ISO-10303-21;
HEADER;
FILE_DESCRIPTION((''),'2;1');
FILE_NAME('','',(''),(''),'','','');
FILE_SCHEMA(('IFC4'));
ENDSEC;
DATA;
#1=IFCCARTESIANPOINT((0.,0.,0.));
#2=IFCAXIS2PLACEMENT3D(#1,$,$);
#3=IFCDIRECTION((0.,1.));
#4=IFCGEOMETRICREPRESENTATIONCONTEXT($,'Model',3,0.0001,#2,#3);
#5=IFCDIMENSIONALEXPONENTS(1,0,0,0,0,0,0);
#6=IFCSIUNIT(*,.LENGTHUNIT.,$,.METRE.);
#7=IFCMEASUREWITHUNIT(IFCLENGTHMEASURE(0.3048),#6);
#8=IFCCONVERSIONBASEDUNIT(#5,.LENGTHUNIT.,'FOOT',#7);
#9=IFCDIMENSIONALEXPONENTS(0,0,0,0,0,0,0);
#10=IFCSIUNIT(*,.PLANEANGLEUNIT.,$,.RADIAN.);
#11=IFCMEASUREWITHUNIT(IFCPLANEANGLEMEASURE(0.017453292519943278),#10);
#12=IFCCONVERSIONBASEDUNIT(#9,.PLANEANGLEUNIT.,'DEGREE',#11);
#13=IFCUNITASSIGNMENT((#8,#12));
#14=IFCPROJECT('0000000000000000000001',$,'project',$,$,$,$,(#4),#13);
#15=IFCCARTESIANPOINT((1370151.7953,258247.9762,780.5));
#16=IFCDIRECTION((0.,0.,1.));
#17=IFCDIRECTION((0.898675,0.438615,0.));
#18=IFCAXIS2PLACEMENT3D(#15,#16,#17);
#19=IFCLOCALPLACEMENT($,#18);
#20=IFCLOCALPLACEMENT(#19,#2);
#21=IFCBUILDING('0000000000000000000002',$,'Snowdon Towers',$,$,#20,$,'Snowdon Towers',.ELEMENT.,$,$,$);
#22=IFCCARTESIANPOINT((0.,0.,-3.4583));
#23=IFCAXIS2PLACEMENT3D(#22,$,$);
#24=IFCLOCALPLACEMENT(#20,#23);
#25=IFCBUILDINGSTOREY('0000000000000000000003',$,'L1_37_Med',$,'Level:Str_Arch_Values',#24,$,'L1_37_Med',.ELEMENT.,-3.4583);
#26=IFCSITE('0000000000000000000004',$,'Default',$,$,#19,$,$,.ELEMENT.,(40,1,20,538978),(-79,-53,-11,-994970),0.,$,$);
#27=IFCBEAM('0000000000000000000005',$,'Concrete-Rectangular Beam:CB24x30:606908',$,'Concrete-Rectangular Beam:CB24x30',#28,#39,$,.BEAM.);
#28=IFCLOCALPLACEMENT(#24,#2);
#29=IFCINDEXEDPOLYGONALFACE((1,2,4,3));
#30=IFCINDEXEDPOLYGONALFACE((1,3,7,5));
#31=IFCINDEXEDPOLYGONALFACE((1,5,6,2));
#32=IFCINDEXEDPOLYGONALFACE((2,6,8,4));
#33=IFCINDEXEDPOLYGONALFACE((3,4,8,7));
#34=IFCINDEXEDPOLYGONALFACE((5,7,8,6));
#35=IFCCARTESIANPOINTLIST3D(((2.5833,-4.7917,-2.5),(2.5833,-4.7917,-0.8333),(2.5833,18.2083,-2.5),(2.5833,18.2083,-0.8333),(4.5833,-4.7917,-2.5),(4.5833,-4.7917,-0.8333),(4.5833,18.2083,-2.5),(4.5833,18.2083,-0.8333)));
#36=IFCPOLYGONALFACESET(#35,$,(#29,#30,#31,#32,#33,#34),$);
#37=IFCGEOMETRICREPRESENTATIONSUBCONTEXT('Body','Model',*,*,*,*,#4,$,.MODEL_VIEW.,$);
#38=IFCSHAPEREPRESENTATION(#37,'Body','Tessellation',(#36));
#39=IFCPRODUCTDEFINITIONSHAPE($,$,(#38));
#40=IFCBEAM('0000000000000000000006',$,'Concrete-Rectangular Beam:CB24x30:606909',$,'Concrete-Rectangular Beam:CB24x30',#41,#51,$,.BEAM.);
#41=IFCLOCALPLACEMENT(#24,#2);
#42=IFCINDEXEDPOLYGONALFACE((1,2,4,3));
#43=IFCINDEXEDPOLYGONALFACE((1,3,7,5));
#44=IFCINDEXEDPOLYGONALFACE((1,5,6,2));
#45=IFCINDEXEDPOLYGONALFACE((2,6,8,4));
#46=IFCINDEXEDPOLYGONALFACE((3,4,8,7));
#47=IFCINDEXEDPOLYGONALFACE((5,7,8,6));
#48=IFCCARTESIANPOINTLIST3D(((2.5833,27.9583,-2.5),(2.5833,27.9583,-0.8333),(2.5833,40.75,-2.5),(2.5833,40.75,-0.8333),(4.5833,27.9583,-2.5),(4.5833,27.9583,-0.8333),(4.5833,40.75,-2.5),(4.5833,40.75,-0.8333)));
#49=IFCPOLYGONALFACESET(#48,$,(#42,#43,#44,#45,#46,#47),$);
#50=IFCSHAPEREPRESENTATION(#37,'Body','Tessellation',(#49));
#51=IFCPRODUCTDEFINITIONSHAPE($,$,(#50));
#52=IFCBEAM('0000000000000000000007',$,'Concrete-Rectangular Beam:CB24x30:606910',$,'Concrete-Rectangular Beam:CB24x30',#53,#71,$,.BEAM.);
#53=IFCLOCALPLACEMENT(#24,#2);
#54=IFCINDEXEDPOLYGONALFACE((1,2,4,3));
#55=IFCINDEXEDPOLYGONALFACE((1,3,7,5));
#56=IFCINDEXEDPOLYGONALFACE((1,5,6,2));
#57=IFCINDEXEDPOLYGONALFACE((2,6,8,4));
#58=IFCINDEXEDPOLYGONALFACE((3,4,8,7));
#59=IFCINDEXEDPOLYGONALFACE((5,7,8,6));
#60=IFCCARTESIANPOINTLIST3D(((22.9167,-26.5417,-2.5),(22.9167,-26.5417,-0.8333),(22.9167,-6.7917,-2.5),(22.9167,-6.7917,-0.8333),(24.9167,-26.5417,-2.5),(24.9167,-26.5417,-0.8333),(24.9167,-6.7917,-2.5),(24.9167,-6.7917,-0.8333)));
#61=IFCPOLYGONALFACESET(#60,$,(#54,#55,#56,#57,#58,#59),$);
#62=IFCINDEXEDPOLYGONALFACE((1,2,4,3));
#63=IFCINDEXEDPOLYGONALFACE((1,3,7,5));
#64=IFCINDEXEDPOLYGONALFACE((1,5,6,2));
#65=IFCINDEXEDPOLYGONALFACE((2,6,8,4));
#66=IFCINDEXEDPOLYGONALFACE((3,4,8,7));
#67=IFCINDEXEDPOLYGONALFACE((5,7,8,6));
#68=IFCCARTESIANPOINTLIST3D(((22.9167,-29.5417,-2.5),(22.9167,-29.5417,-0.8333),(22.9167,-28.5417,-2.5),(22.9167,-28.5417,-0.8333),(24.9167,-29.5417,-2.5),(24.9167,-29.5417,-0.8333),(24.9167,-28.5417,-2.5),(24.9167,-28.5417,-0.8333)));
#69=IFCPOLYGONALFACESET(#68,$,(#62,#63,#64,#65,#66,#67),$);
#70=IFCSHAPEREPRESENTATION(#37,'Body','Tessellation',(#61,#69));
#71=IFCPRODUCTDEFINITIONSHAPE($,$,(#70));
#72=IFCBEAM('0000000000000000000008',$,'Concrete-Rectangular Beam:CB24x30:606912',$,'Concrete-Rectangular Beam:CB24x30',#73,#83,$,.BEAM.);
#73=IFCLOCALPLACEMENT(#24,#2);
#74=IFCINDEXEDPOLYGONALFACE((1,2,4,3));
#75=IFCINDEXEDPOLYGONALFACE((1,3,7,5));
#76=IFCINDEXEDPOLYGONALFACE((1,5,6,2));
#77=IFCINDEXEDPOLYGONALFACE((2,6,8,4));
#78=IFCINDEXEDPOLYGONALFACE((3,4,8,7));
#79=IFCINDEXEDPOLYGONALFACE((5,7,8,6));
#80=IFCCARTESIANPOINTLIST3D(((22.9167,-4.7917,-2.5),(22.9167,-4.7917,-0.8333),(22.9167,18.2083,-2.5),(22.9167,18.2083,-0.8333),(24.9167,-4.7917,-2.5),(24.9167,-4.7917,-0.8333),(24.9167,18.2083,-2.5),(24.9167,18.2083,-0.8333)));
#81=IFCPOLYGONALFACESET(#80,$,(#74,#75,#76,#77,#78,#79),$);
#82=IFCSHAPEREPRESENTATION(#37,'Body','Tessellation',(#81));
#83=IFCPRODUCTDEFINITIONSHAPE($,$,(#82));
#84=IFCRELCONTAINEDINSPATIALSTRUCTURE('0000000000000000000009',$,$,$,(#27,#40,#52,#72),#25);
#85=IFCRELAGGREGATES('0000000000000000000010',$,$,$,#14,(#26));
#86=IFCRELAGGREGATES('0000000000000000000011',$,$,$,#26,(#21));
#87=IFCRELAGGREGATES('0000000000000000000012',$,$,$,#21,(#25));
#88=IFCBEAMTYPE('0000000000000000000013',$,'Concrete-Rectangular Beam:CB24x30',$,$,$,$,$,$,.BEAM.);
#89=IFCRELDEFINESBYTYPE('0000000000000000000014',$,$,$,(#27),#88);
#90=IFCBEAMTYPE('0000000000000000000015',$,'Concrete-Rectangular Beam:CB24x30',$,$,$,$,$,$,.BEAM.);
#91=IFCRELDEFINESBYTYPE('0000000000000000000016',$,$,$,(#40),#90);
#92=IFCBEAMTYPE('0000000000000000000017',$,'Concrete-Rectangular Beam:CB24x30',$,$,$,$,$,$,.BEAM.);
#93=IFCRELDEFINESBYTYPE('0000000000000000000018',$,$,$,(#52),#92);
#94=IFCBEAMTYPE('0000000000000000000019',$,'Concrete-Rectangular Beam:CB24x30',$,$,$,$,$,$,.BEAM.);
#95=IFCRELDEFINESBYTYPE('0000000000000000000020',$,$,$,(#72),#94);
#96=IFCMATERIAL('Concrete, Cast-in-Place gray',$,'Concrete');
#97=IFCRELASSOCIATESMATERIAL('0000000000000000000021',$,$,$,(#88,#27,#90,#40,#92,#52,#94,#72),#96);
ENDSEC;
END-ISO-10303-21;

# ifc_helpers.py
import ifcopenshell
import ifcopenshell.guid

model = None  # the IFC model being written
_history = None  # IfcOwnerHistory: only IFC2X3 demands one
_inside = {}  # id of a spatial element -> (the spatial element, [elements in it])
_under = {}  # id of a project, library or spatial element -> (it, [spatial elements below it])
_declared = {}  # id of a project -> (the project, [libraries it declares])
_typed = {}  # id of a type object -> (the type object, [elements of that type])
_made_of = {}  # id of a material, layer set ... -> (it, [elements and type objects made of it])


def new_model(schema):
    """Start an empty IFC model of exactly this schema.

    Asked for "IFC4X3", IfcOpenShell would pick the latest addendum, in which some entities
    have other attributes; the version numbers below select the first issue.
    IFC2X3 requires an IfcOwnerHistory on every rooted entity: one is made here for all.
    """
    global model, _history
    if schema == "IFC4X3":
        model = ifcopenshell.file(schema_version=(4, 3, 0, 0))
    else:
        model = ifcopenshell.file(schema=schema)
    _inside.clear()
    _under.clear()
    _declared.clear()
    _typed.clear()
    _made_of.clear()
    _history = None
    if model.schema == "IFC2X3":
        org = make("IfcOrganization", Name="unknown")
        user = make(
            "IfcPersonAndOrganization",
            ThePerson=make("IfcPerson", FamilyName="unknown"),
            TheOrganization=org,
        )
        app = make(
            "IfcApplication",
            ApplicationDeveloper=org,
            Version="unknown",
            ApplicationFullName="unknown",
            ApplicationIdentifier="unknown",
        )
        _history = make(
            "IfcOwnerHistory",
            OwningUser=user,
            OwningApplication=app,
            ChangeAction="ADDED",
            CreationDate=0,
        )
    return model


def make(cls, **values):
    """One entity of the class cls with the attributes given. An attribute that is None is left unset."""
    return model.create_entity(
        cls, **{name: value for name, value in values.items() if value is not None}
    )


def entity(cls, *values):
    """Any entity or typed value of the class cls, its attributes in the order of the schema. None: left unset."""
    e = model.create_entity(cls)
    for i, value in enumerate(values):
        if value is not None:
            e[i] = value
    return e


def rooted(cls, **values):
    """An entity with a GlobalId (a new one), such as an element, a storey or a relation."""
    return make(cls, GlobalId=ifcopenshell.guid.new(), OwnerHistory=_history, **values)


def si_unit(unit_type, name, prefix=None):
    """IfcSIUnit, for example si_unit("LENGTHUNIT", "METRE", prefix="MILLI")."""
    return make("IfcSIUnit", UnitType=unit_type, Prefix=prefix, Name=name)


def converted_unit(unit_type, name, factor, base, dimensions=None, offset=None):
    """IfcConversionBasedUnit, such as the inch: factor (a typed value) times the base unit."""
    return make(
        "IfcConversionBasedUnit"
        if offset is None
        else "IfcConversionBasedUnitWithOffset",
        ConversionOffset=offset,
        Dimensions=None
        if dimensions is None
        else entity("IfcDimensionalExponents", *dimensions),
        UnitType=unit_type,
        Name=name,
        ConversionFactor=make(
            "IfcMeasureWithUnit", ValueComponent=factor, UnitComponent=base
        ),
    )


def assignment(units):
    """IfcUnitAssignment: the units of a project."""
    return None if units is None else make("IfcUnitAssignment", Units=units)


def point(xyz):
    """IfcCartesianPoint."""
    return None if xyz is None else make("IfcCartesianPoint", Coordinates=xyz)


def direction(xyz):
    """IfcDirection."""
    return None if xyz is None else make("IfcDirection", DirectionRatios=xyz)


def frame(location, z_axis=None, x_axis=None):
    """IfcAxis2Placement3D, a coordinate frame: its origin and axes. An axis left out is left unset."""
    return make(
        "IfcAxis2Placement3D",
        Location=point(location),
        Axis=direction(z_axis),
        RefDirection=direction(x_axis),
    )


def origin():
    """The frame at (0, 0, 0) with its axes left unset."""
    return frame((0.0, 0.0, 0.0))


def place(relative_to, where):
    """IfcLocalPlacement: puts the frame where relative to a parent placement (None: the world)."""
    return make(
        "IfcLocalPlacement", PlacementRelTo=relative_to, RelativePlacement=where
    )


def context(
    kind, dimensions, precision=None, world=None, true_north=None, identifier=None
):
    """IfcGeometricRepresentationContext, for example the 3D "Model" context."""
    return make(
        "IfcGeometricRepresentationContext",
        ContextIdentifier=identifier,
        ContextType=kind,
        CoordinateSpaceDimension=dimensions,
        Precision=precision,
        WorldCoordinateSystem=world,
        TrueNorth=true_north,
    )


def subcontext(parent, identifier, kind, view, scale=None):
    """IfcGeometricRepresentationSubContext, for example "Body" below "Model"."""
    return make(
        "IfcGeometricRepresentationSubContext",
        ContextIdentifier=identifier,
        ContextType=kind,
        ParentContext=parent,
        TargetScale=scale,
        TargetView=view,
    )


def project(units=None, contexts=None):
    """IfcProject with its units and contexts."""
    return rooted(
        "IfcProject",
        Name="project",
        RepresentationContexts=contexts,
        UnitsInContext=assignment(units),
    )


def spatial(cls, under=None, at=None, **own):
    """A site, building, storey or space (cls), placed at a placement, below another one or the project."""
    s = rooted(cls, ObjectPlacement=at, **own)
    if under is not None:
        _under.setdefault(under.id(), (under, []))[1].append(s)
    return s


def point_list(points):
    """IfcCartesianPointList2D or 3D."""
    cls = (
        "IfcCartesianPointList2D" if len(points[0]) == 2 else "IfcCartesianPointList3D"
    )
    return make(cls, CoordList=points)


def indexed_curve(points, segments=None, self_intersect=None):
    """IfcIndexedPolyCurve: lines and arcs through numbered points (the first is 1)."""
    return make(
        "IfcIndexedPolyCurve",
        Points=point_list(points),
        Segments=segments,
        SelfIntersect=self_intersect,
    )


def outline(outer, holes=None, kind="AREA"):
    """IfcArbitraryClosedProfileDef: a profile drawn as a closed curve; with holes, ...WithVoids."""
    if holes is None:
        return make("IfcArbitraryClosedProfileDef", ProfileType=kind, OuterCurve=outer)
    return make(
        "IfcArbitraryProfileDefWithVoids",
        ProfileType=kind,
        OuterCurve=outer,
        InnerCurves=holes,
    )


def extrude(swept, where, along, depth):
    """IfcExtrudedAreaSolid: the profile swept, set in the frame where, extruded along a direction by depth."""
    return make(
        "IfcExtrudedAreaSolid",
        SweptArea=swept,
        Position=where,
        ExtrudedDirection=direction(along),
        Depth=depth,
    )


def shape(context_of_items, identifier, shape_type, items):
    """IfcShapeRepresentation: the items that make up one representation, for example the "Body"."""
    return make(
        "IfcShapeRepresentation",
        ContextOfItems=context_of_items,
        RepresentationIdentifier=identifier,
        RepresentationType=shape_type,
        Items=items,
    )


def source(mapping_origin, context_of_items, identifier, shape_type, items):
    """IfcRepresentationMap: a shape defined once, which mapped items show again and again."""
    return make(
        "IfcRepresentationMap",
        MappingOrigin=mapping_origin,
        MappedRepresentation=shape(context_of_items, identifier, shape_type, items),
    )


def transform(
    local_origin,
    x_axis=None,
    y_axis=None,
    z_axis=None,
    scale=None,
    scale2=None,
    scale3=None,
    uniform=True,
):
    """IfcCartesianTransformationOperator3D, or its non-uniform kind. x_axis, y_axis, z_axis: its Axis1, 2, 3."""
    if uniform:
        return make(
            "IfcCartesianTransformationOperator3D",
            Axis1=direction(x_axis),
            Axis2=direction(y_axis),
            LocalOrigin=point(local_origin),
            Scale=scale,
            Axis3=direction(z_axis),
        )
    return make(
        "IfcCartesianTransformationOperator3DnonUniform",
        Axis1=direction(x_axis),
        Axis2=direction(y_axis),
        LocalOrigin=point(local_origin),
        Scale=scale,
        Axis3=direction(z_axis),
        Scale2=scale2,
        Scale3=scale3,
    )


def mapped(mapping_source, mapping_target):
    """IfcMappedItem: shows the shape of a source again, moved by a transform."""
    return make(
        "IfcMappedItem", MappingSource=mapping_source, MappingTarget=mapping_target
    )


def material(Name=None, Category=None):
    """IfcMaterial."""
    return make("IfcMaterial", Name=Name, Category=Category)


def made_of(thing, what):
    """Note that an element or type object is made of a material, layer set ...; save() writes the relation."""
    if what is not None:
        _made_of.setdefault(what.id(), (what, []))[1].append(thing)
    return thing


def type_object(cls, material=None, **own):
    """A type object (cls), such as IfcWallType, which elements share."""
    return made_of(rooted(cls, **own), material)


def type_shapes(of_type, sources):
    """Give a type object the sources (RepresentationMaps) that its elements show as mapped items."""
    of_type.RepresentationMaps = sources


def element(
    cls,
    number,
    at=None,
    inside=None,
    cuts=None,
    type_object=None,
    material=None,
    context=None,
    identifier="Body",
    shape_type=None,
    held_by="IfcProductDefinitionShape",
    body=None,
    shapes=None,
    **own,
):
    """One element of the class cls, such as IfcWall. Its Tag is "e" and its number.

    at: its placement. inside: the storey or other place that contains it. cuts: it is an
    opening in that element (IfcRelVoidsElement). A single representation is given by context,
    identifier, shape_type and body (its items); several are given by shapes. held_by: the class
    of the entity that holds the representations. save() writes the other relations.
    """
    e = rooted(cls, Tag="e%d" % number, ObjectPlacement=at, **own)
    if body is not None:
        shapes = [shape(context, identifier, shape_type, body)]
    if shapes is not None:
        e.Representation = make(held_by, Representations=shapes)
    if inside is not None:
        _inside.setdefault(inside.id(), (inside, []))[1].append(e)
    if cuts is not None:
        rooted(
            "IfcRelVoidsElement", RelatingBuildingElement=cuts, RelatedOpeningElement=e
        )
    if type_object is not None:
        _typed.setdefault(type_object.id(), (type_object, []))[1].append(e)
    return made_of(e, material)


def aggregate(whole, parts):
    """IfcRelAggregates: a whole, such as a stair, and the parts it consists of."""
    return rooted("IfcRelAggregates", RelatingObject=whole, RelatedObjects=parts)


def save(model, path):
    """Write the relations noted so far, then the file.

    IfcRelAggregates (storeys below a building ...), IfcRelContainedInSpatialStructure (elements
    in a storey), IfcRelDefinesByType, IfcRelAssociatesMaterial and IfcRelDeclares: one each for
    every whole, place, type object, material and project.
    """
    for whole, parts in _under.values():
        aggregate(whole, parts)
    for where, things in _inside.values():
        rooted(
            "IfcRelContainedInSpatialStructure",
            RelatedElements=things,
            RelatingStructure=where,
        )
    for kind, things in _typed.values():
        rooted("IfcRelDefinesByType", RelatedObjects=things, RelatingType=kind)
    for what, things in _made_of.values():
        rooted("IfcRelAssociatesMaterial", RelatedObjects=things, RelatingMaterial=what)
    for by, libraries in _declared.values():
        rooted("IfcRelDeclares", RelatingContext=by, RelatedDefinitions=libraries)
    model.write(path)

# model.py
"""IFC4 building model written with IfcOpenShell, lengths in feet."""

from ifc_helpers import new_model, entity, si_unit, converted_unit, direction, frame, origin, place, context, subcontext, project, spatial, indexed_curve, outline, extrude, source, transform, mapped, material, type_object, type_shapes, element, save


model = new_model("IFC4")

# Units and contexts
model_context = context("Model", 3, precision=0.0001, world=origin(), true_north=direction((0.0, 1.0)))
body_context = subcontext(model_context, "Body", "Model", "MODEL_VIEW")
ifc_project = project(units=[converted_unit("LENGTHUNIT", "FOOT", entity("IfcLengthMeasure", 0.3048), si_unit("LENGTHUNIT", "METRE"), dimensions=[1, 0, 0, 0, 0, 0, 0]), converted_unit("PLANEANGLEUNIT", "DEGREE", entity("IfcPlaneAngleMeasure", 0.017453292519943278), si_unit("PLANEANGLEUNIT", "RADIAN"), dimensions=[0, 0, 0, 0, 0, 0, 0])], contexts=[model_context])

# Site, building, storey
site_placement = place(None, frame((1370151.7953, 258247.9762, 780.5), z_axis=(0.0, 0.0, 1.0), x_axis=(0.898675, 0.438615, 0.0)))
site = spatial("IfcSite", under=ifc_project, at=site_placement, Name="Default", CompositionType="ELEMENT", RefLatitude=(40, 1, 20, 538978), RefLongitude=(-79, -53, -11, -994970), RefElevation=0.0)
building_placement = place(site_placement, origin())
building = spatial("IfcBuilding", under=site, at=building_placement, Name="Snowdon Towers", LongName="Snowdon Towers", CompositionType="ELEMENT")
storey_placement = place(building_placement, frame((0.0, 0.0, -3.4583)))
storey = spatial("IfcBuildingStorey", under=building, at=storey_placement, Name="L1_37_Med", ObjectType="Level:Str_Arch_Values", LongName="L1_37_Med", CompositionType="ELEMENT", Elevation=-3.4583)

# Beams
ifc_material_1 = material(Name="Concrete, Cast-in-Place gray", Category="Concrete")
beam_type_1 = type_object("IfcBeamType", Name="Concrete-Rectangular Beam:CB24x30", PredefinedType="BEAM", material=ifc_material_1)
shared_shape_1 = source(origin(), body_context, "Body", "SweptSolid", [
    extrude(outline(indexed_curve([(-1.0, -0.8333), (1.0, -0.8333), (1.0, 0.8333), (-1.0, 0.8333), (-1.0, -0.8333)], self_intersect=False)), frame((3.5833, -4.7917, -5.125), z_axis=(0.0, 1.0, 0.0), x_axis=(-1.0, 0.0, 0.0)), (0.0, 0.0, 1.0), 23.0),
])
type_shapes(beam_type_1, [shared_shape_1])
beam_1_placement = place(storey_placement, frame((0.0, 0.0, 3.4583)))
element("IfcBeam", 1, at=beam_1_placement, inside=storey, type_object=beam_type_1, material=ifc_material_1, Name="Concrete-Rectangular Beam:CB24x30:606908", ObjectType="Concrete-Rectangular Beam:CB24x30", PredefinedType="BEAM", context=body_context, shape_type="MappedRepresentation", body=[
    mapped(shared_shape_1, transform((0.0, 0.0, 0.0), scale=1.0)),
])
beam_type_2 = type_object("IfcBeamType", Name="Concrete-Rectangular Beam:CB24x30", PredefinedType="BEAM", material=ifc_material_1)
shared_shape_2 = source(origin(), body_context, "Body", "SweptSolid", [
    extrude(outline(indexed_curve([(-1.0, -0.8333), (1.0, -0.8333), (1.0, 0.8333), (-1.0, 0.8333), (-1.0, -0.8333)], self_intersect=False)), frame((3.5833, 27.9583, -5.125), z_axis=(0.0, 1.0, 0.0), x_axis=(-1.0, 0.0, 0.0)), (0.0, 0.0, 1.0), 12.7917),
])
type_shapes(beam_type_2, [shared_shape_2])
beam_2_placement = place(storey_placement, frame((0.0, 0.0, 3.4583)))
element("IfcBeam", 2, at=beam_2_placement, inside=storey, type_object=beam_type_2, material=ifc_material_1, Name="Concrete-Rectangular Beam:CB24x30:606909", ObjectType="Concrete-Rectangular Beam:CB24x30", PredefinedType="BEAM", context=body_context, shape_type="MappedRepresentation", body=[
    mapped(shared_shape_2, transform((0.0, 0.0, 0.0), scale=1.0)),
])
beam_type_3 = type_object("IfcBeamType", Name="Concrete-Rectangular Beam:CB24x30", PredefinedType="BEAM", material=ifc_material_1)
shared_shape_3 = source(origin(), body_context, "Body", "SweptSolid", [
    extrude(outline(indexed_curve([(-1.0, -0.8333), (1.0, -0.8333), (1.0, 0.8333), (-1.0, 0.8333), (-1.0, -0.8333)], self_intersect=False)), frame((23.9167, -26.5417, -5.125), z_axis=(0.0, 1.0, 0.0), x_axis=(-1.0, 0.0, 0.0)), (0.0, 0.0, 1.0), 19.75),
    extrude(outline(indexed_curve([(-1.0, -0.8333), (1.0, -0.8333), (1.0, 0.8333), (-1.0, 0.8333), (-1.0, -0.8333)], self_intersect=False)), frame((23.9167, -29.5417, -5.125), z_axis=(0.0, 1.0, 0.0), x_axis=(-1.0, 0.0, 0.0)), (0.0, 0.0, 1.0), 1.0),
])
type_shapes(beam_type_3, [shared_shape_3])
beam_3_placement = place(storey_placement, frame((0.0, 0.0, 3.4583)))
element("IfcBeam", 3, at=beam_3_placement, inside=storey, type_object=beam_type_3, material=ifc_material_1, Name="Concrete-Rectangular Beam:CB24x30:606910", ObjectType="Concrete-Rectangular Beam:CB24x30", PredefinedType="BEAM", context=body_context, shape_type="MappedRepresentation", body=[
    mapped(shared_shape_3, transform((0.0, 0.0, 0.0), scale=1.0)),
])
beam_type_4 = type_object("IfcBeamType", Name="Concrete-Rectangular Beam:CB24x30", PredefinedType="BEAM", material=ifc_material_1)
shared_shape_4 = source(origin(), body_context, "Body", "SweptSolid", [
    extrude(outline(indexed_curve([(-1.0, -0.8333), (1.0, -0.8333), (1.0, 0.8333), (-1.0, 0.8333), (-1.0, -0.8333)], self_intersect=False)), frame((23.9167, -4.7917, -5.125), z_axis=(0.0, 1.0, 0.0), x_axis=(-1.0, 0.0, 0.0)), (0.0, 0.0, 1.0), 23.0),
])
type_shapes(beam_type_4, [shared_shape_4])
beam_4_placement = place(storey_placement, frame((0.0, 0.0, 3.4583)))
element("IfcBeam", 4, at=beam_4_placement, inside=storey, type_object=beam_type_4, material=ifc_material_1, Name="Concrete-Rectangular Beam:CB24x30:606912", ObjectType="Concrete-Rectangular Beam:CB24x30", PredefinedType="BEAM", context=body_context, shape_type="MappedRepresentation", body=[
    mapped(shared_shape_4, transform((0.0, 0.0, 0.0), scale=1.0)),
])

save(model, "model.ifc")
